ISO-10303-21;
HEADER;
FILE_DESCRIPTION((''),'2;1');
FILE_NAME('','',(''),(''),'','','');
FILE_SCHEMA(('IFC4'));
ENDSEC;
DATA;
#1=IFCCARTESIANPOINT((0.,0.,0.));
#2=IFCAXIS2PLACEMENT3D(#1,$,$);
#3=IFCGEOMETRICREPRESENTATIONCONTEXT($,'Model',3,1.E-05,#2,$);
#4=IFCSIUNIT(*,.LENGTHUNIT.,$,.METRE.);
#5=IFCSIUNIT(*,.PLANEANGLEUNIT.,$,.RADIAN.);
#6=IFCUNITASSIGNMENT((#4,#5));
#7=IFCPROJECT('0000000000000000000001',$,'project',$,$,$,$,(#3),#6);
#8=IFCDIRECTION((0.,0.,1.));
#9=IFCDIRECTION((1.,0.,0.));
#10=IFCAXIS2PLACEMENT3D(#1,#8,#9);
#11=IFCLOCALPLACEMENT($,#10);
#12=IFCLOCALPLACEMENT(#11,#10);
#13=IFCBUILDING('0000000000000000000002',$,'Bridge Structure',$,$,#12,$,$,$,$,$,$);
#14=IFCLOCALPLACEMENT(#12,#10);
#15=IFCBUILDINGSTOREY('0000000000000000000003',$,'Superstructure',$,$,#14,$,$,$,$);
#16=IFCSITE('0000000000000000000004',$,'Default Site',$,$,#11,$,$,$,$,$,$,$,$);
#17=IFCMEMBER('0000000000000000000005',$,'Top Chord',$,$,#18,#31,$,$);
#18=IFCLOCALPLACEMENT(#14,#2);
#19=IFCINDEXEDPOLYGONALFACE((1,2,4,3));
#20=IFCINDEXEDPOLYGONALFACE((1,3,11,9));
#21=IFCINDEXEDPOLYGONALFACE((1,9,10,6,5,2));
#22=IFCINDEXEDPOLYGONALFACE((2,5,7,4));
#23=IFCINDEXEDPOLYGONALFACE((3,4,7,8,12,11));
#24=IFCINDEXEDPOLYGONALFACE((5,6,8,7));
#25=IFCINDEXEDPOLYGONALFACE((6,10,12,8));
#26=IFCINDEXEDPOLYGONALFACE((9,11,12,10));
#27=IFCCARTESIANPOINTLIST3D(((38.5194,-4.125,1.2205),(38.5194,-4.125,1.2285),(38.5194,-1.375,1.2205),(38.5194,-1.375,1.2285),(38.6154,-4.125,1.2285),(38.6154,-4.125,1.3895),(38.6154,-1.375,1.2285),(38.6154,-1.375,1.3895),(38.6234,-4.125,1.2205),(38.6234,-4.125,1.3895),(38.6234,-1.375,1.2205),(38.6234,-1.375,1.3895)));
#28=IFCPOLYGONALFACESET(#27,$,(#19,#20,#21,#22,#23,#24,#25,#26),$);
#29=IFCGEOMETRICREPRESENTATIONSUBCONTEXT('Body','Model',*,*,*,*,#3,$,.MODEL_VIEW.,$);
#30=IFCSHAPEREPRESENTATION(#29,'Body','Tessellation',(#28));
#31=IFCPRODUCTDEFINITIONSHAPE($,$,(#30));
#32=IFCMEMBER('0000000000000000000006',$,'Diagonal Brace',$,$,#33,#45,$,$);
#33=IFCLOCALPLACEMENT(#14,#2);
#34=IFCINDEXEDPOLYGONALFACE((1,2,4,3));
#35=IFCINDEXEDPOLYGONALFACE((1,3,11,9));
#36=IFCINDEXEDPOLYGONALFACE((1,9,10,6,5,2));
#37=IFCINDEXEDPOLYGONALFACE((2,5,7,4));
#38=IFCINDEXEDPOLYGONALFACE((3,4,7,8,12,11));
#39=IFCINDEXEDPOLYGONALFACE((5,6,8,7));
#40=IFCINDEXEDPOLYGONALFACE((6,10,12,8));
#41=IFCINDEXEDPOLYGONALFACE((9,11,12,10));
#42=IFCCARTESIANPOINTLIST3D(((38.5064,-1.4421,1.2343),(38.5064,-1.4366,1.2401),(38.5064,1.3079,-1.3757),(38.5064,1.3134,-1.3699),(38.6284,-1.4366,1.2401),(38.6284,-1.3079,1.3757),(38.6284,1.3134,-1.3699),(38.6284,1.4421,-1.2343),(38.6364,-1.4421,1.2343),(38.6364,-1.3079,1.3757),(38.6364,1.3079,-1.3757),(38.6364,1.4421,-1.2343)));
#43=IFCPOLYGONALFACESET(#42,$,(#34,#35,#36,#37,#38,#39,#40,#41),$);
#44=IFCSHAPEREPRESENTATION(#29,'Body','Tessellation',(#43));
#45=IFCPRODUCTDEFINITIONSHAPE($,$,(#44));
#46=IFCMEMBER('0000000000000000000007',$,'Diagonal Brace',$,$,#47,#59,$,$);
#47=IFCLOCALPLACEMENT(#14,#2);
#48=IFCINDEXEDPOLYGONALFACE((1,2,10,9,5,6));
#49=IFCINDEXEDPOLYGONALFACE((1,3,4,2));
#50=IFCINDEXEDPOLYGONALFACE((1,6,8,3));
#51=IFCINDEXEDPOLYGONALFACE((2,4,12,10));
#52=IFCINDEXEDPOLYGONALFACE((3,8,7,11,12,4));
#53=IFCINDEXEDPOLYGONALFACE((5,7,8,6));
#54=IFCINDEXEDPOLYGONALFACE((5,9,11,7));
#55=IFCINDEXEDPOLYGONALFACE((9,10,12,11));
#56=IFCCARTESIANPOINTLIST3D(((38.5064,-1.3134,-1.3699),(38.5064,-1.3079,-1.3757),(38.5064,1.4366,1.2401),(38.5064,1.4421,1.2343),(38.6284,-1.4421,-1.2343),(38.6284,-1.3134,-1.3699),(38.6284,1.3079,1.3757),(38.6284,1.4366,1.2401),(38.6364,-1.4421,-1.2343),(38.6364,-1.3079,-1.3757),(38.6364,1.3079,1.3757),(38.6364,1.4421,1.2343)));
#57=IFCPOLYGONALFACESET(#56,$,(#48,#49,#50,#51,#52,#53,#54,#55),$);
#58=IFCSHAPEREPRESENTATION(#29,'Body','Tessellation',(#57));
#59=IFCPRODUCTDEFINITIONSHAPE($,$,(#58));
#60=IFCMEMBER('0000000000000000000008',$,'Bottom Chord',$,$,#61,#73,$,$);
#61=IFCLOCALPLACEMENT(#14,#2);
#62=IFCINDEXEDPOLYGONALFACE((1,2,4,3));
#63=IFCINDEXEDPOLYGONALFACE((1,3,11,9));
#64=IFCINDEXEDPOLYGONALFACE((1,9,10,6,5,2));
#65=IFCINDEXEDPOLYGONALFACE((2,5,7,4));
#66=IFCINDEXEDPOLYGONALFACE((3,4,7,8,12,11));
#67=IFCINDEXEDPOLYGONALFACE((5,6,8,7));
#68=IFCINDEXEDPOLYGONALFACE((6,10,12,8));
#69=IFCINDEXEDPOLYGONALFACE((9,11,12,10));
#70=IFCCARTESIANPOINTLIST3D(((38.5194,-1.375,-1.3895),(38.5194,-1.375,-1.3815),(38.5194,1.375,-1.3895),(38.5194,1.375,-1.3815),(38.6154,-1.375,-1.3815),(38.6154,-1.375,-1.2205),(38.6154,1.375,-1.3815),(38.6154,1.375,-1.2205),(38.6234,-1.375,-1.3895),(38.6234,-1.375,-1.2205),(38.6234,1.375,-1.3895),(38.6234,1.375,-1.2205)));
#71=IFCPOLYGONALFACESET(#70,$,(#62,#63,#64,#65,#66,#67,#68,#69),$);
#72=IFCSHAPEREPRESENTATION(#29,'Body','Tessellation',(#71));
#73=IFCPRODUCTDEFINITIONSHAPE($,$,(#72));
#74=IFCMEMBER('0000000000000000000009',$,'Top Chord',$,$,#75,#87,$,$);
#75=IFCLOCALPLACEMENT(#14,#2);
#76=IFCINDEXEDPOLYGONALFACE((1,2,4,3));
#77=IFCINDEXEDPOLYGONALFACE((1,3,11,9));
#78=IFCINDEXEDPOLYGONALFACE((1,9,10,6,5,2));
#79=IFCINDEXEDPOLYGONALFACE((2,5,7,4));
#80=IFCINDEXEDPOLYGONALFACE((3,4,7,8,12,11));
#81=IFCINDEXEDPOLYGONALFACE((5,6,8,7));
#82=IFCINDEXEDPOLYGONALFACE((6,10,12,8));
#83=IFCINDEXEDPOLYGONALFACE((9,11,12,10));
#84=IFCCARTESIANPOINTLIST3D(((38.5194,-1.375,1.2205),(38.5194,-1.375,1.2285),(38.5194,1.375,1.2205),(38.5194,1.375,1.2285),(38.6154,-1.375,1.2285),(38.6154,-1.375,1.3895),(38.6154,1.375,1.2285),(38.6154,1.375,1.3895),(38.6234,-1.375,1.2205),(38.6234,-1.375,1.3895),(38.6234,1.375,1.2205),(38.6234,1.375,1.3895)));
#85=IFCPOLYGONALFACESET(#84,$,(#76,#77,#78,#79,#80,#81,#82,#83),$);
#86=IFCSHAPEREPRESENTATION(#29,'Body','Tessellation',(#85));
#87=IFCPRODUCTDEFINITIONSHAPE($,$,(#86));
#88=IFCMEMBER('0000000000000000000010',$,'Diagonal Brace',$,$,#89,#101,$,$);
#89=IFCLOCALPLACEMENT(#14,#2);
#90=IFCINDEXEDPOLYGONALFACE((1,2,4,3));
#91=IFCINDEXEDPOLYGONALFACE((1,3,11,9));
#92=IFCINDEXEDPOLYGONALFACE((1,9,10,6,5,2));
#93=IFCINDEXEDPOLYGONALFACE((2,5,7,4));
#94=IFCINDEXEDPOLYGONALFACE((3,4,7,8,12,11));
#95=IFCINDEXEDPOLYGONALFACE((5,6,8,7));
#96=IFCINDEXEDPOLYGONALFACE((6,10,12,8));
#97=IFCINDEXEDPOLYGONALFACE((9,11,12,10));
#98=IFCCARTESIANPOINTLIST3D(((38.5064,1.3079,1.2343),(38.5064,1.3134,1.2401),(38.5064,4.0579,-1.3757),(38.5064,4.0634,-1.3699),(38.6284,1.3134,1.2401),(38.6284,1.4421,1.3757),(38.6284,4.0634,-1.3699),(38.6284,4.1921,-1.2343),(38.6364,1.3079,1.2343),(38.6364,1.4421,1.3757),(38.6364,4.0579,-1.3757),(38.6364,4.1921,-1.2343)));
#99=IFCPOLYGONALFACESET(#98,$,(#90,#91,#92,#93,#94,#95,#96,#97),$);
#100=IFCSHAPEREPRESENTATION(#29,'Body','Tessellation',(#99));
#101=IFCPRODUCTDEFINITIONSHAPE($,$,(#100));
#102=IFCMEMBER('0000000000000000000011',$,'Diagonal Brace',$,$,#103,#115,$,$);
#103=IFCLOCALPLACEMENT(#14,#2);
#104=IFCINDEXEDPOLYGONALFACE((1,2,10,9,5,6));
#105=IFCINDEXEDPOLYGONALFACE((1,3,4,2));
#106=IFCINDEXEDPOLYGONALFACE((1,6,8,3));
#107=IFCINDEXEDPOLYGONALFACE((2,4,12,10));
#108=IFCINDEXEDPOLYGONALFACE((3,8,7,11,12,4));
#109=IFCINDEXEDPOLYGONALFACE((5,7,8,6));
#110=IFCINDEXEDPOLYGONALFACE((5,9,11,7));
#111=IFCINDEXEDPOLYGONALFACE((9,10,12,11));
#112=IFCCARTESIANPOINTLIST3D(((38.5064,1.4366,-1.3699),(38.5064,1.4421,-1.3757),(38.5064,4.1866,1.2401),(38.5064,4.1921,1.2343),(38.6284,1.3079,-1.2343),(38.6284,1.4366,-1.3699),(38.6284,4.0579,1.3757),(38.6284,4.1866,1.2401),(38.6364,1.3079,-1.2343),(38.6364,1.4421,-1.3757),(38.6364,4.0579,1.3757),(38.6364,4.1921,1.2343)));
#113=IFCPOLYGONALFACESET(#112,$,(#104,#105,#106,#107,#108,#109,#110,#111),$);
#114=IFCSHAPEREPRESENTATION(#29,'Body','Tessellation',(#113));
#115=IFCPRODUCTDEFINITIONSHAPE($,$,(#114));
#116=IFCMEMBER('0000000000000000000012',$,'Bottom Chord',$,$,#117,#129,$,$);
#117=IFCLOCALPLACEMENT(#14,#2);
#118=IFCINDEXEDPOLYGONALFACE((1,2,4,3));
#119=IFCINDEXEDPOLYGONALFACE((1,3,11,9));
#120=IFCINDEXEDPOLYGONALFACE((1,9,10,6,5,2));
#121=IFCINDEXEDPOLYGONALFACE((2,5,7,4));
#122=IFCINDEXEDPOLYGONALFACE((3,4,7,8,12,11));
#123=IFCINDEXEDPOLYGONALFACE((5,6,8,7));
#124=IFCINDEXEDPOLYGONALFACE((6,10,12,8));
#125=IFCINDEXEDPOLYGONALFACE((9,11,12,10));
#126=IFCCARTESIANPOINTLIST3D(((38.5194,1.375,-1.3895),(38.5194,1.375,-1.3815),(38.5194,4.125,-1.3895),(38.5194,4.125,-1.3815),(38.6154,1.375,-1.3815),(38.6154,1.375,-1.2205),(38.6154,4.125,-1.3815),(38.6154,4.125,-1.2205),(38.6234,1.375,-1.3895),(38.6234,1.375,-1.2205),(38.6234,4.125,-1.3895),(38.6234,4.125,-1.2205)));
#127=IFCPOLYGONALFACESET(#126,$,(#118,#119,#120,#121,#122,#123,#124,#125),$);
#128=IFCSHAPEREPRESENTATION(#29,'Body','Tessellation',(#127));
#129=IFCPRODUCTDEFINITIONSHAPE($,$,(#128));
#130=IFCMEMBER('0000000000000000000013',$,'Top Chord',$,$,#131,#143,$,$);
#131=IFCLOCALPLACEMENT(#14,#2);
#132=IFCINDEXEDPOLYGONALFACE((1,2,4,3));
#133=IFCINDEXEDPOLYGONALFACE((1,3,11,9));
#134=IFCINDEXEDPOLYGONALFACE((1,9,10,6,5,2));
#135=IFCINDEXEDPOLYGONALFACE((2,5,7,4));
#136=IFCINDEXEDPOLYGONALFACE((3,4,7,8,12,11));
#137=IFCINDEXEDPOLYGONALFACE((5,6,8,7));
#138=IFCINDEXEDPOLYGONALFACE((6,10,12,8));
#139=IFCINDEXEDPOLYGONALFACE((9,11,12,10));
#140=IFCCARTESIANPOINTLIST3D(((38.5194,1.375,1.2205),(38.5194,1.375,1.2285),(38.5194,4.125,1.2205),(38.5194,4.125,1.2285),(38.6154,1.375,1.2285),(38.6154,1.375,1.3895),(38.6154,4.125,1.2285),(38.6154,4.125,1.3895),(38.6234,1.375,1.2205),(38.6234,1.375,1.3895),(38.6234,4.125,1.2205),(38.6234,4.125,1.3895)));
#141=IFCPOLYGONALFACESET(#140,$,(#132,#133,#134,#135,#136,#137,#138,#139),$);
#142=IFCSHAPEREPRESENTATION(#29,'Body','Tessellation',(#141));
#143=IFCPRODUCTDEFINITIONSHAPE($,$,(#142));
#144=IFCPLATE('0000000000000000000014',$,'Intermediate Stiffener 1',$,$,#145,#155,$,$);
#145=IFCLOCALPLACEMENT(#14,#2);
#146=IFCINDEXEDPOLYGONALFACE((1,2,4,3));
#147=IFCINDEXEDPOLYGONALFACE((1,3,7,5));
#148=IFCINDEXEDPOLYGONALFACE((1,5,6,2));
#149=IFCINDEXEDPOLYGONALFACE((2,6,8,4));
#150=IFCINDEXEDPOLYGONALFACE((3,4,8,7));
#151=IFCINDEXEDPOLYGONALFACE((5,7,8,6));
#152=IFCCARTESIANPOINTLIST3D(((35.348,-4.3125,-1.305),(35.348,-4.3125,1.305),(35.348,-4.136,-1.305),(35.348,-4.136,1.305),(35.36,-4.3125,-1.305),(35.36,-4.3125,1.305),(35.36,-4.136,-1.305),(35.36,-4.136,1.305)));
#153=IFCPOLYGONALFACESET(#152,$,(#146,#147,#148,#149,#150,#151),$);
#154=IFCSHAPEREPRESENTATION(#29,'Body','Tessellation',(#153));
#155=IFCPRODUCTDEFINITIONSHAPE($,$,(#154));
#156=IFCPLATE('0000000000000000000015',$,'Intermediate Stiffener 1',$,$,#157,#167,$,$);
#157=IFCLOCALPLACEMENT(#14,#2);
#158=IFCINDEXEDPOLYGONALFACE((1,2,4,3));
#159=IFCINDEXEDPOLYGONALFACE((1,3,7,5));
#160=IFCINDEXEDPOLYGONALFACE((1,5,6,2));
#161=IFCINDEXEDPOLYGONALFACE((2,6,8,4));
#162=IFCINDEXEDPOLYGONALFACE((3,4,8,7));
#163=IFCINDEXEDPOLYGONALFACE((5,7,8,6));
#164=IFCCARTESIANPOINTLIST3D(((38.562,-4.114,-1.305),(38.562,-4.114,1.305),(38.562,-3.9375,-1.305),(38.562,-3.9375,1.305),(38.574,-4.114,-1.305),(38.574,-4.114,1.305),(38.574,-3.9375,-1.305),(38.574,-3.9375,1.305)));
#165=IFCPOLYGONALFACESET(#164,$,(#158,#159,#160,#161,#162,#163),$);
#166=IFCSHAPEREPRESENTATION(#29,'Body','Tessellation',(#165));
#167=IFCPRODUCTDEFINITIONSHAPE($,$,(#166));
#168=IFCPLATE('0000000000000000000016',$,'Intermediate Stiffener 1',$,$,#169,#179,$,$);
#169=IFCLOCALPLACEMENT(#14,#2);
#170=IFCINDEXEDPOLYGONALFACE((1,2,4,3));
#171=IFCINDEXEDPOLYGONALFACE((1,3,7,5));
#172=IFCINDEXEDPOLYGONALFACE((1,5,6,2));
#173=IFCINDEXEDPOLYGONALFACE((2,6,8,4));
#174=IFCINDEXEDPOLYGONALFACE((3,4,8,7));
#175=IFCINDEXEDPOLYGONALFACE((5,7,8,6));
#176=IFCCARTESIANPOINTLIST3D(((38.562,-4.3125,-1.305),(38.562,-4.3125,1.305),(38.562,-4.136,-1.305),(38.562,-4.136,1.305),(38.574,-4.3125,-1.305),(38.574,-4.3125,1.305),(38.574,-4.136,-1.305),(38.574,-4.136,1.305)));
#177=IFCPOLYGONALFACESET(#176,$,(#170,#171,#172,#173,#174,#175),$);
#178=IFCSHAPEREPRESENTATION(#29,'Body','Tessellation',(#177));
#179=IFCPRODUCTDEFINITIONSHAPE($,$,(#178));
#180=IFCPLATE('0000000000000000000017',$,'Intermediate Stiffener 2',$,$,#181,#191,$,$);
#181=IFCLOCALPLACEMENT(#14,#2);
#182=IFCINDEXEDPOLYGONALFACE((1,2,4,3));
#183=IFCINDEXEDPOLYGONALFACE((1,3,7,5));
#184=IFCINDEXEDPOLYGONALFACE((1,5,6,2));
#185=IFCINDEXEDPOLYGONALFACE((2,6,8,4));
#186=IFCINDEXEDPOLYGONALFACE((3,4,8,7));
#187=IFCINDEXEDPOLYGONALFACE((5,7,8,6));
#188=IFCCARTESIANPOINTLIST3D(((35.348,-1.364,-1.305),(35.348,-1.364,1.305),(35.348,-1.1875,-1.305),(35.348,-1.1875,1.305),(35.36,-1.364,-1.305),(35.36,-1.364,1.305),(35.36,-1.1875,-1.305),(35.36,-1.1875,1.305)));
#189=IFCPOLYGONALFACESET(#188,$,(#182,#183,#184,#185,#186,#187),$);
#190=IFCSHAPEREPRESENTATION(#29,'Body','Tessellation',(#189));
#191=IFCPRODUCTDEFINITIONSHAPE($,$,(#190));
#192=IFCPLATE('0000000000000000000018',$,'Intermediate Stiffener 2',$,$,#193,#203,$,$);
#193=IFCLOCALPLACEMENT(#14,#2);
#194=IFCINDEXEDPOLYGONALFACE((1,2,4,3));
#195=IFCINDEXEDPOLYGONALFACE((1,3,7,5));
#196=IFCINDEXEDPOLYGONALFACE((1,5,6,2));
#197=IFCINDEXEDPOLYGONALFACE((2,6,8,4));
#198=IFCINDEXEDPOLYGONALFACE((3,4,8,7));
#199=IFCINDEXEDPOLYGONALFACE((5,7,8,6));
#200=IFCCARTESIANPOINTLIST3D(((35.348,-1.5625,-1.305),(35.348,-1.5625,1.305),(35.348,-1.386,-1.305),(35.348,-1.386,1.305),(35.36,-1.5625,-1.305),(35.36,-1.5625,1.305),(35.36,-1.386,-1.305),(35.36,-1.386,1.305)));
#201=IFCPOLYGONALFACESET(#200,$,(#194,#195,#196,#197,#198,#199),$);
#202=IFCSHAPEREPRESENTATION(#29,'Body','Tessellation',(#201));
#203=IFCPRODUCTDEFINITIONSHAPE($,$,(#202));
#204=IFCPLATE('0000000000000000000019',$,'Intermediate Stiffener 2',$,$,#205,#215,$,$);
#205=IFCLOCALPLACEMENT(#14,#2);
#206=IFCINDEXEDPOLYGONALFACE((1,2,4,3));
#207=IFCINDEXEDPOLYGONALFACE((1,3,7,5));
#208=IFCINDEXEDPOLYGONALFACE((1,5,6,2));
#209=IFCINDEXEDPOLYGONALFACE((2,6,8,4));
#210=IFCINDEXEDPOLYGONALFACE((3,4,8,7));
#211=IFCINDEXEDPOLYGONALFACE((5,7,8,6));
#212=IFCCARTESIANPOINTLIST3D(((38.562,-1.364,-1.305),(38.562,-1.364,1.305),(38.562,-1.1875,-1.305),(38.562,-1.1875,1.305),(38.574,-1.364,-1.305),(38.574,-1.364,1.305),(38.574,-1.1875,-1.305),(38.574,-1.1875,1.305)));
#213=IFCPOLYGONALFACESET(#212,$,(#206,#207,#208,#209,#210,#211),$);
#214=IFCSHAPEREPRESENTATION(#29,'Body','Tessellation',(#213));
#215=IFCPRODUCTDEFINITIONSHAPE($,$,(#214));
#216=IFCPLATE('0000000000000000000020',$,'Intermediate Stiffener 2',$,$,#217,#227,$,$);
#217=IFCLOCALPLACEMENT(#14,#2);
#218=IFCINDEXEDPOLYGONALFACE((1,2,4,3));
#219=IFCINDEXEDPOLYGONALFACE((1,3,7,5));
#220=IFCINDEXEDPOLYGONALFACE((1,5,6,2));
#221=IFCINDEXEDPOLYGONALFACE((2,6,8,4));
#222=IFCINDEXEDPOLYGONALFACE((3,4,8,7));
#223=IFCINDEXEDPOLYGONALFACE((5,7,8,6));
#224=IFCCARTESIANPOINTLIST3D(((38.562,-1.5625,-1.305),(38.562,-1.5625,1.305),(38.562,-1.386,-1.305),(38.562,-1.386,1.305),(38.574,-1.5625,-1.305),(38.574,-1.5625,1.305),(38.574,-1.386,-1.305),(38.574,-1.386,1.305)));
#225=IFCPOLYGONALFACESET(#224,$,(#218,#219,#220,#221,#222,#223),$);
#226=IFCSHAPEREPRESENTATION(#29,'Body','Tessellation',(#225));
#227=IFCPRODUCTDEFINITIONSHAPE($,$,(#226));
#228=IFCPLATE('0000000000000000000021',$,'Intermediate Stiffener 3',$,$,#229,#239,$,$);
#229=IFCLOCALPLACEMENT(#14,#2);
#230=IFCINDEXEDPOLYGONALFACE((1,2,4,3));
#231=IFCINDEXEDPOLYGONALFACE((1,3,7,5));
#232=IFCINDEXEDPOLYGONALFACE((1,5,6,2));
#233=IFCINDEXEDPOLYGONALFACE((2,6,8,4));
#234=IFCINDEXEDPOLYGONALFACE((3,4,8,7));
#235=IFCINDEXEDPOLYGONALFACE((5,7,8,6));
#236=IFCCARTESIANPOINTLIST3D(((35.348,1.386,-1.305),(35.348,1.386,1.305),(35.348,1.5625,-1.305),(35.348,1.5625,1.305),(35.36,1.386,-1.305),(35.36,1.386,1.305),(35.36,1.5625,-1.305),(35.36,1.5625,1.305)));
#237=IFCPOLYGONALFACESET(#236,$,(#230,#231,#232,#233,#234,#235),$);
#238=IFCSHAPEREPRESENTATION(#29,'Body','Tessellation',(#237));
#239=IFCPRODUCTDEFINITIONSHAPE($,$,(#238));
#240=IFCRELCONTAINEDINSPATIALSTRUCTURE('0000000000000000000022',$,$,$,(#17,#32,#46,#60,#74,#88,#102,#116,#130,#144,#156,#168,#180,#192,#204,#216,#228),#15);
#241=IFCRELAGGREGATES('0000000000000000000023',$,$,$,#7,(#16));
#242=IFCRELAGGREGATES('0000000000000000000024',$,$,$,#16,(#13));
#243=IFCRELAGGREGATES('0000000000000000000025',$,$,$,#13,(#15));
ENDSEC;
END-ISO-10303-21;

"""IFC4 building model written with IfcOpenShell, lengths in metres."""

from ifc_helpers import new_model, si_unit, frame, origin, origin_with_axes, origin_2d_with_axis, place, context, subcontext, project, spatial, rectangle, l_section, extrude, element, save


model = new_model("IFC4")

# Units and contexts
model_context = context("Model", 3, precision=1e-05, world=origin())
body_context = subcontext(model_context, "Body", "Model", "MODEL_VIEW")
ifc_project = project(units=[si_unit("LENGTHUNIT", "METRE"), si_unit("PLANEANGLEUNIT", "RADIAN")], contexts=[model_context])

# Site, building, storey
site_placement = place(None, origin_with_axes())
site = spatial("IfcSite", under=ifc_project, at=site_placement, Name="Default Site")
building_placement = place(site_placement, origin_with_axes())
building = spatial("IfcBuilding", under=site, at=building_placement, Name="Bridge Structure")
storey_placement = place(building_placement, origin_with_axes())
storey = spatial("IfcBuildingStorey", under=building, at=storey_placement, Name="Superstructure")

# Members
for number, where, z_axis, x_axis, name in (
    (1, (38.5714, -4.125, 1.305), (0.0, 1.0, 0.0), (-1.0, 0.0, 0.0), "Top Chord"),
):
    element("IfcMember", number, at=place(storey_placement, frame(where, z_axis=z_axis, x_axis=x_axis)), inside=storey, Name=name, context=body_context, shape_type="SweptSolid", body=[
        extrude(l_section(Depth=0.169, Width=0.104, Thickness=0.008, at=origin_2d_with_axis()), origin_with_axes(), (0.0, 0.0, 1.0), 2.75),
    ])
for number, where, z_axis, x_axis, name in (
    (2, (38.5714, -1.375, 1.305), (0.0, 0.725329, -0.688403), (-1.0, 0.0, 0.0), "Diagonal Brace"),
    (3, (38.5714, -1.375, -1.305), (0.0, 0.725329, 0.688403), (-1.0, 0.0, 0.0), "Diagonal Brace"),
):
    element("IfcMember", number, at=place(storey_placement, frame(where, z_axis=z_axis, x_axis=x_axis)), inside=storey, Name=name, context=body_context, shape_type="SweptSolid", body=[
        extrude(l_section(Depth=0.195, Width=0.13, Thickness=0.008, at=origin_2d_with_axis()), origin_with_axes(), (0.0, 0.0, 1.0), 3.7914),
    ])
for number, where, z_axis, x_axis, name in (
    (4, (38.5714, -1.375, -1.305), (0.0, 1.0, 0.0), (-1.0, 0.0, 0.0), "Bottom Chord"),
    (5, (38.5714, -1.375, 1.305), (0.0, 1.0, 0.0), (-1.0, 0.0, 0.0), "Top Chord"),
):
    element("IfcMember", number, at=place(storey_placement, frame(where, z_axis=z_axis, x_axis=x_axis)), inside=storey, Name=name, context=body_context, shape_type="SweptSolid", body=[
        extrude(l_section(Depth=0.169, Width=0.104, Thickness=0.008, at=origin_2d_with_axis()), origin_with_axes(), (0.0, 0.0, 1.0), 2.75),
    ])
for number, where, z_axis, x_axis, name in (
    (6, (38.5714, 1.375, 1.305), (0.0, 0.725329, -0.688403), (-1.0, 0.0, 0.0), "Diagonal Brace"),
    (7, (38.5714, 1.375, -1.305), (0.0, 0.725329, 0.688403), (-1.0, 0.0, 0.0), "Diagonal Brace"),
):
    element("IfcMember", number, at=place(storey_placement, frame(where, z_axis=z_axis, x_axis=x_axis)), inside=storey, Name=name, context=body_context, shape_type="SweptSolid", body=[
        extrude(l_section(Depth=0.195, Width=0.13, Thickness=0.008, at=origin_2d_with_axis()), origin_with_axes(), (0.0, 0.0, 1.0), 3.7914),
    ])
for number, where, z_axis, x_axis, name in (
    (8, (38.5714, 1.375, -1.305), (0.0, 1.0, 0.0), (-1.0, 0.0, 0.0), "Bottom Chord"),
    (9, (38.5714, 1.375, 1.305), (0.0, 1.0, 0.0), (-1.0, 0.0, 0.0), "Top Chord"),
):
    element("IfcMember", number, at=place(storey_placement, frame(where, z_axis=z_axis, x_axis=x_axis)), inside=storey, Name=name, context=body_context, shape_type="SweptSolid", body=[
        extrude(l_section(Depth=0.169, Width=0.104, Thickness=0.008, at=origin_2d_with_axis()), origin_with_axes(), (0.0, 0.0, 1.0), 2.75),
    ])

# Plates
for number, where, z_axis, x_axis, name in (
    (10, (35.354, -4.2243, -1.305), (0.0, 0.0, 1.0), (1.0, 0.0, 0.0), "Intermediate Stiffener 1"),
    (11, (38.568, -4.0258, -1.305), (0.0, 0.0, 1.0), (1.0, 0.0, 0.0), "Intermediate Stiffener 1"),
    (12, (38.568, -4.2243, -1.305), (0.0, 0.0, 1.0), (1.0, 0.0, 0.0), "Intermediate Stiffener 1"),
    (13, (35.354, -1.2757, -1.305), (0.0, 0.0, 1.0), (1.0, 0.0, 0.0), "Intermediate Stiffener 2"),
    (14, (35.354, -1.4743, -1.305), (0.0, 0.0, 1.0), (1.0, 0.0, 0.0), "Intermediate Stiffener 2"),
    (15, (38.568, -1.2757, -1.305), (0.0, 0.0, 1.0), (1.0, 0.0, 0.0), "Intermediate Stiffener 2"),
    (16, (38.568, -1.4743, -1.305), (0.0, 0.0, 1.0), (1.0, 0.0, 0.0), "Intermediate Stiffener 2"),
    (17, (35.354, 1.4743, -1.305), (0.0, 0.0, 1.0), (1.0, 0.0, 0.0), "Intermediate Stiffener 3"),
):
    element("IfcPlate", number, at=place(storey_placement, frame(where, z_axis=z_axis, x_axis=x_axis)), inside=storey, Name=name, context=body_context, shape_type="SweptSolid", body=[
        extrude(rectangle(XDim=0.012, YDim=0.1765, at=origin_2d_with_axis()), origin_with_axes(), (0.0, 0.0, 1.0), 2.61),
    ])

save(model, "model.ifc")
